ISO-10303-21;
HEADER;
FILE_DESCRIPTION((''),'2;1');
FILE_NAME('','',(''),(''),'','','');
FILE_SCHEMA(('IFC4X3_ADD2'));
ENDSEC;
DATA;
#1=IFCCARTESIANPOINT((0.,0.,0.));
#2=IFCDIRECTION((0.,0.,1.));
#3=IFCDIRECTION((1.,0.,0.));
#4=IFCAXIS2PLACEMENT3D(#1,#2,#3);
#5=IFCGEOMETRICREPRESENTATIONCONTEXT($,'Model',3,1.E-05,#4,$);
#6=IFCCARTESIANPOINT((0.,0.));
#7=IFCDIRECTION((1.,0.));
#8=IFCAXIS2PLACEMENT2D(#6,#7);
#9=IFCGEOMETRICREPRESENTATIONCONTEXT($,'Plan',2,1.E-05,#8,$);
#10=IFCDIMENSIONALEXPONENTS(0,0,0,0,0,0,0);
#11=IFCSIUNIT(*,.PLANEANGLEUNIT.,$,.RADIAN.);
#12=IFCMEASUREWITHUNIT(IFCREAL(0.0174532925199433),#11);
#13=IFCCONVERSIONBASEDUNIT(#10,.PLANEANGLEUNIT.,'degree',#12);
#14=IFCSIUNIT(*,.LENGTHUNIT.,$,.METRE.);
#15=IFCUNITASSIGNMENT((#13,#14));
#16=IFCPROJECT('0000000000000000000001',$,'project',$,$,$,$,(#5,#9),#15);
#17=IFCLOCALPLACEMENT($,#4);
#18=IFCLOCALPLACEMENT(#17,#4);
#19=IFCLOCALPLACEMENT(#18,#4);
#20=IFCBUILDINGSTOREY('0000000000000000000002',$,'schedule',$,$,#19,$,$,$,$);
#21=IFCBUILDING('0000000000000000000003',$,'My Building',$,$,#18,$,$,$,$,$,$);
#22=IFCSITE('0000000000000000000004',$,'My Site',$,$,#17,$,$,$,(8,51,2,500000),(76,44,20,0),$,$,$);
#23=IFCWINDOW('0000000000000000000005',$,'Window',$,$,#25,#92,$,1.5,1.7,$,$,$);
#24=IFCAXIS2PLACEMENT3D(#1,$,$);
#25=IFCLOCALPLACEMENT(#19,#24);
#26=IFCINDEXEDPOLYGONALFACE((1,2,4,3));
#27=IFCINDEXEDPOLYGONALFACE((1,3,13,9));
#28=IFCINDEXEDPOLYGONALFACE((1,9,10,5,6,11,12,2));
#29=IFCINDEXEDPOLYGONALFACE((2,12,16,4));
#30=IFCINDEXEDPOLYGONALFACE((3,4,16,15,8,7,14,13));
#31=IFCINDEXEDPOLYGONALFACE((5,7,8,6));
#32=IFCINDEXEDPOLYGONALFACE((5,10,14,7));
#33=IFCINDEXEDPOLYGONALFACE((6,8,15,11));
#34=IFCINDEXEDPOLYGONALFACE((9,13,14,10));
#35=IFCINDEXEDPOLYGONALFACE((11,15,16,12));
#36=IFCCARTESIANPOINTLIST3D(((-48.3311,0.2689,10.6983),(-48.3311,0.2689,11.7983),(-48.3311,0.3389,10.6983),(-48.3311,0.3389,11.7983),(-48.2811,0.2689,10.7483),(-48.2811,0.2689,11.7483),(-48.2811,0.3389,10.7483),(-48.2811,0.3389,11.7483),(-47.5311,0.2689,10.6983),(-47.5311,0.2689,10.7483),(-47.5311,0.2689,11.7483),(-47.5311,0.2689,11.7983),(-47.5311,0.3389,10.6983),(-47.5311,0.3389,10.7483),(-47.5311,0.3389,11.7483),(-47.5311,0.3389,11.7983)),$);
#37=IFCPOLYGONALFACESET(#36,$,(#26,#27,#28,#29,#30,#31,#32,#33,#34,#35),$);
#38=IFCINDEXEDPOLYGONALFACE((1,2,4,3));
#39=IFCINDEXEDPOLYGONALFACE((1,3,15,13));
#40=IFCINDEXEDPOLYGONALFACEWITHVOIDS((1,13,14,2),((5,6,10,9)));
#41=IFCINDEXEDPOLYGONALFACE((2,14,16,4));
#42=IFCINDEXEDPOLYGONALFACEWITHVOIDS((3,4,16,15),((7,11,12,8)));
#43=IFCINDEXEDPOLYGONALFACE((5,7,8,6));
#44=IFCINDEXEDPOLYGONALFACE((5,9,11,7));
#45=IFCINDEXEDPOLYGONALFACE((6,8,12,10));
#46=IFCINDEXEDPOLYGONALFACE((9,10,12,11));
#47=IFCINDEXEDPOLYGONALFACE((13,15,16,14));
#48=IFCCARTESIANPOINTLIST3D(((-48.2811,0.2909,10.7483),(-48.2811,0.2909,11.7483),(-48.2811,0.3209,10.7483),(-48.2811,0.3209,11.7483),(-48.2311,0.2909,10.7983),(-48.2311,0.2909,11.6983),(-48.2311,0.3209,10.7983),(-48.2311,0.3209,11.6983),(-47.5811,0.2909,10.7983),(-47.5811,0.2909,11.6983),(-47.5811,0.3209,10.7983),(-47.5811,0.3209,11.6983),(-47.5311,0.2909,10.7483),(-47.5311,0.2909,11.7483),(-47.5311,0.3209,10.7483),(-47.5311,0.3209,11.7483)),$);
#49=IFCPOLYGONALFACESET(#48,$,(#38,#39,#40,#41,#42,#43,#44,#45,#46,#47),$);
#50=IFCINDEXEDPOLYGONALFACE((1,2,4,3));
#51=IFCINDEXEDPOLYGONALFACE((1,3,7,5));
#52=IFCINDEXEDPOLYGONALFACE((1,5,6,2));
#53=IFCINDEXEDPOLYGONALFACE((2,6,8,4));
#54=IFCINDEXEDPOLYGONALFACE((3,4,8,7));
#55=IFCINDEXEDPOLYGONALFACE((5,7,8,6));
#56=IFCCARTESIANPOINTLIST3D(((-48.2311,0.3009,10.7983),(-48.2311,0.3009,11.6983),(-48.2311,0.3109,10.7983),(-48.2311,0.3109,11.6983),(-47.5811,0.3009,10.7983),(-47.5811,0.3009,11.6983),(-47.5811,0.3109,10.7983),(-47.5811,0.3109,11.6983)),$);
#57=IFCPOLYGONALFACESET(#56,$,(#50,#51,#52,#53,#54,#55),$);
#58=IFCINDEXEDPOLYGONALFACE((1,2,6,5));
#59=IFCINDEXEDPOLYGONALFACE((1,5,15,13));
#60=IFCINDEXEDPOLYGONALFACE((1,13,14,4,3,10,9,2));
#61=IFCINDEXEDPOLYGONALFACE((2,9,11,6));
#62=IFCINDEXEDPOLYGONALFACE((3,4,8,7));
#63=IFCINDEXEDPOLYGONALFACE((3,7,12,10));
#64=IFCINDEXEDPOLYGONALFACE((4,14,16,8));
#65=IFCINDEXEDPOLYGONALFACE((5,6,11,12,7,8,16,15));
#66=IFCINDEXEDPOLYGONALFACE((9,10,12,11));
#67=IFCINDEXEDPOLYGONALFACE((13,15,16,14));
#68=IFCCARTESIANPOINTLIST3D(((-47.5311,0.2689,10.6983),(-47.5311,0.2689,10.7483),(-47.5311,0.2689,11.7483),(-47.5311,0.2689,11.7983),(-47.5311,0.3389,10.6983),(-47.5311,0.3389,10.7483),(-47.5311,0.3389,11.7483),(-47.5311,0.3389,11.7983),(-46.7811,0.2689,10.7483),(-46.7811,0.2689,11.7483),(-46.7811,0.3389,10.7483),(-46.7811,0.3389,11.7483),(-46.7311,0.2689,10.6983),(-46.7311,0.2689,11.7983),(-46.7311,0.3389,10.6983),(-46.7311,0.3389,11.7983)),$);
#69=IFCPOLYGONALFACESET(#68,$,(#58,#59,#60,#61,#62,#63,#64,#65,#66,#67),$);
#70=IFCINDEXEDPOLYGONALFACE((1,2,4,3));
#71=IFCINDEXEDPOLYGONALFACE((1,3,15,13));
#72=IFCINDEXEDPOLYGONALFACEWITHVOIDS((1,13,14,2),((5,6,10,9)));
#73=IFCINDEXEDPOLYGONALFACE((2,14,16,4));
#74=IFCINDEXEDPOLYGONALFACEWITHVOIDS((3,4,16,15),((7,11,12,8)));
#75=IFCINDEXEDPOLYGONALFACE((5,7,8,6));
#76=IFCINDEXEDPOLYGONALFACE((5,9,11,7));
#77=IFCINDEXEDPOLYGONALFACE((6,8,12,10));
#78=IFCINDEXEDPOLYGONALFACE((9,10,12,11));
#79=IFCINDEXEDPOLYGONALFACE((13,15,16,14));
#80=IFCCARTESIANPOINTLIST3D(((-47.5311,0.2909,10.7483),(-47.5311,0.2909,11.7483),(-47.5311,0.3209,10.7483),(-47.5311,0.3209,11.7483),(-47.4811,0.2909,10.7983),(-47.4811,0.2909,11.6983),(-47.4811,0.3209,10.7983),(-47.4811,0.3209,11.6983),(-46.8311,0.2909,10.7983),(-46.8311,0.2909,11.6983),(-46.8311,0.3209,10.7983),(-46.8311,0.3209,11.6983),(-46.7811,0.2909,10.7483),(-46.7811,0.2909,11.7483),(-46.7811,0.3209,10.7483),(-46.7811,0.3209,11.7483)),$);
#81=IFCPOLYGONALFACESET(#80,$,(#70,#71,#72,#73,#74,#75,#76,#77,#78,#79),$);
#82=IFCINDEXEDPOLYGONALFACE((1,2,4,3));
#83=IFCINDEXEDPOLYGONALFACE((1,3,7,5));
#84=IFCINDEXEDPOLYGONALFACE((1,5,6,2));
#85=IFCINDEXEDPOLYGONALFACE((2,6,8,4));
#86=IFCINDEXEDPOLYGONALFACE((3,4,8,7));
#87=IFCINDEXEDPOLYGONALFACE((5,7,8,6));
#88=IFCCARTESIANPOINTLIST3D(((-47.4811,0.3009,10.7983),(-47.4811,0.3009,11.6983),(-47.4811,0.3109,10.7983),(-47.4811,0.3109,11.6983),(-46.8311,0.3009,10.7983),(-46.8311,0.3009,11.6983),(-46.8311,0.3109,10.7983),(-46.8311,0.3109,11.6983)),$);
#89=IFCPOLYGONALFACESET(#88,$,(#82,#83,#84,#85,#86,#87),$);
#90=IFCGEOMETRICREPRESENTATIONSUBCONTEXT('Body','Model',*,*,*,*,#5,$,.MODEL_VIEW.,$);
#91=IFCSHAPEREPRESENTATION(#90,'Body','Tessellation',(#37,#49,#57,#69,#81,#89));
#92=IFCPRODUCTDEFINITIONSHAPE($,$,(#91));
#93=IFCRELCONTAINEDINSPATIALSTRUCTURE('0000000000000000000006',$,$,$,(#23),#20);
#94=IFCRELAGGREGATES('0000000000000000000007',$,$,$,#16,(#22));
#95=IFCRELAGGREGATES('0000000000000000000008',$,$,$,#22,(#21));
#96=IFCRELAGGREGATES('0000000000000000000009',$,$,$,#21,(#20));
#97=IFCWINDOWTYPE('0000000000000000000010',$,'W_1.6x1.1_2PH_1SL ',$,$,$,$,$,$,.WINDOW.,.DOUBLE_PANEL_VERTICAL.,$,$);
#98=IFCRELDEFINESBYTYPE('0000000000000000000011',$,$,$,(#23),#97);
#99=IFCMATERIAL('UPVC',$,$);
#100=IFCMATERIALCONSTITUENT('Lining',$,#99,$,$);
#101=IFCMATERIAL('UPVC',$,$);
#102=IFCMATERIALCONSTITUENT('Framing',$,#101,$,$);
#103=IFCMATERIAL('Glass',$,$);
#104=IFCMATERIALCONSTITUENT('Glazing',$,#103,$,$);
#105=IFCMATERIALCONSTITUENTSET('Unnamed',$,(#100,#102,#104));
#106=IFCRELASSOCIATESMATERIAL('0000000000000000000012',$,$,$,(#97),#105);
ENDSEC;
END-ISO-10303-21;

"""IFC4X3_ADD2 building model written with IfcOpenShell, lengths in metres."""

from ifc_helpers import new_model, entity, si_unit, converted_unit, frame, origin_with_axes, origin_2d_with_axis, place, context, subcontext, project, spatial, line, indexed_curve, outline, extrude, shape, source, transform, mapped, material, constituent, constituent_set, type_object, type_shapes, element, save


model = new_model("IFC4X3_ADD2")

# Units and contexts
model_context = context("Model", 3, precision=1e-05, world=origin_with_axes())
plan_context = context("Plan", 2, precision=1e-05, world=origin_2d_with_axis())
body_context_1 = subcontext(model_context, "Body", "Model", "MODEL_VIEW")
body_context_2 = subcontext(plan_context, "Body", "Plan", "PLAN_VIEW")
ifc_project = project(units=[converted_unit("PLANEANGLEUNIT", "degree", entity("IfcReal", 0.0174532925199433), si_unit("PLANEANGLEUNIT", "RADIAN"), dimensions=[0, 0, 0, 0, 0, 0, 0]), si_unit("LENGTHUNIT", "METRE")], contexts=[model_context, plan_context])

# Site, building, storey
site_placement = place(None, origin_with_axes())
site = spatial("IfcSite", under=ifc_project, at=site_placement, Name="My Site", RefLatitude=(8, 51, 2, 500000), RefLongitude=(76, 44, 20, 0))
building_placement = place(site_placement, origin_with_axes())
building = spatial("IfcBuilding", under=site, at=building_placement, Name="My Building")
storey_placement = place(building_placement, origin_with_axes())
storey = spatial("IfcBuildingStorey", under=building, at=storey_placement, Name="schedule")

# Window
ifc_material_1 = material(Name="UPVC")
ifc_material_2 = material(Name="UPVC")
ifc_material_3 = material(Name="Glass")
placement_1 = place(storey_placement, frame((-67.8485, 0.2689, 3.1152), z_axis=(0.0, 0.0, 1.0), x_axis=(1.0, 0.0, 0.0)))
ifc_constituent_1 = constituent(ifc_material_1, Name="Lining")
ifc_constituent_2 = constituent(ifc_material_2, Name="Framing")
ifc_constituent_3 = constituent(ifc_material_3, Name="Glazing")
ifc_constituent_set_1 = constituent_set(constituents=[ifc_constituent_1, ifc_constituent_2, ifc_constituent_3], Name="Unnamed")
window_type_1 = type_object("IfcWindowType", Name="W_1.6x1.1_2PH_1SL ", PartitioningType="DOUBLE_PANEL_VERTICAL", PredefinedType="WINDOW", material=ifc_constituent_set_1)
shared_shape_1 = source(origin_with_axes(), body_context_1, "Body", "SweptSolid", [
    extrude(outline(indexed_curve([(0.8, 0.0), (0.0, 0.0), (0.0, 1.1), (0.8, 1.1), (0.8, 1.05), (0.05, 1.05), (0.05, 0.05), (0.8, 0.05)], segments=[line(1, 2, 3, 4, 5, 6, 7, 8, 1)])), frame((0.0, 0.0, 0.0), z_axis=(0.0, -1.0, 0.0), x_axis=(1.0, 0.0, 0.0)), (0.0, 0.0, -1.0), 0.07),
    extrude(outline(indexed_curve([(0.0, 0.0), (0.75, 0.0), (0.75, 1.0), (0.0, 1.0)], segments=[line(1, 2, 3, 4, 1)]), holes=[indexed_curve([(0.05, 0.05), (0.7, 0.05), (0.7, 0.95), (0.05, 0.95)], segments=[line(1, 2, 3, 4, 1)])]), frame((0.05, 0.022, 0.05), z_axis=(0.0, -1.0, 0.0), x_axis=(1.0, 0.0, 0.0)), (0.0, 0.0, -1.0), 0.03),
    extrude(outline(indexed_curve([(0.05, 0.05), (0.7, 0.05), (0.7, 0.95), (0.05, 0.95)], segments=[line(1, 2, 3, 4, 1)])), frame((0.05, 0.032, 0.05), z_axis=(0.0, -1.0, 0.0), x_axis=(1.0, 0.0, 0.0)), (0.0, 0.0, -1.0), 0.01),
    extrude(outline(indexed_curve([(0.0, 1.1), (0.8, 1.1), (0.8, 0.0), (0.0, 0.0), (0.0, 0.05), (0.75, 0.05), (0.75, 1.05), (0.0, 1.05)], segments=[line(1, 2, 3, 4, 5, 6, 7, 8, 1)])), frame((0.8, 0.0, 0.0), z_axis=(0.0, -1.0, 0.0), x_axis=(1.0, 0.0, 0.0)), (0.0, 0.0, -1.0), 0.07),
    extrude(outline(indexed_curve([(0.0, 0.0), (0.75, 0.0), (0.75, 1.0), (0.0, 1.0)], segments=[line(1, 2, 3, 4, 1)]), holes=[indexed_curve([(0.05, 0.05), (0.7, 0.05), (0.7, 0.95), (0.05, 0.95)], segments=[line(1, 2, 3, 4, 1)])]), frame((0.8, 0.022, 0.05), z_axis=(0.0, -1.0, 0.0), x_axis=(1.0, 0.0, 0.0)), (0.0, 0.0, -1.0), 0.03),
    extrude(outline(indexed_curve([(0.05, 0.05), (0.7, 0.05), (0.7, 0.95), (0.05, 0.95)], segments=[line(1, 2, 3, 4, 1)])), frame((0.8, 0.032, 0.05), z_axis=(0.0, -1.0, 0.0), x_axis=(1.0, 0.0, 0.0)), (0.0, 0.0, -1.0), 0.01),
])
shared_shape_2 = source(origin_with_axes(), body_context_2, "Body", "Curve2D", [
    entity("IfcIndexedPolyCurve", entity("IfcCartesianPointList2D", [[0.05, 0.0], [0.8, 0.0]])),
    entity("IfcIndexedPolyCurve", entity("IfcCartesianPointList2D", [[0.0, 0.07], [0.05, 0.07], [0.05, 0.0], [0.0, 0.0]]), [entity("IfcLineIndex", [1, 2, 3, 4, 1])]),
    entity("IfcIndexedPolyCurve", entity("IfcCartesianPointList2D", [[0.8, 0.07], [0.8, 0.07], [0.8, 0.0], [0.8, 0.0]])),
    entity("IfcIndexedPolyCurve", entity("IfcCartesianPointList2D", [[0.05, 0.022], [0.1, 0.022], [0.1, 0.052], [0.05, 0.052]]), [entity("IfcLineIndex", [1, 2, 3, 4, 1])]),
    entity("IfcIndexedPolyCurve", entity("IfcCartesianPointList2D", [[0.8, 0.022], [0.75, 0.022], [0.75, 0.052], [0.8, 0.052]]), [entity("IfcLineIndex", [1, 2, 3, 4, 1])]),
    entity("IfcIndexedPolyCurve", entity("IfcCartesianPointList2D", [[0.1, 0.022], [0.75, 0.022]])),
    entity("IfcIndexedPolyCurve", entity("IfcCartesianPointList2D", [[0.1, 0.052], [0.75, 0.052]])),
    entity("IfcIndexedPolyCurve", entity("IfcCartesianPointList2D", [[0.1, 0.037], [0.75, 0.037]])),
    entity("IfcIndexedPolyCurve", entity("IfcCartesianPointList2D", [[0.8, 0.0], [1.55, 0.0]])),
    entity("IfcIndexedPolyCurve", entity("IfcCartesianPointList2D", [[0.8, 0.07], [0.8, 0.07], [0.8, 0.0], [0.8, 0.0]])),
    entity("IfcIndexedPolyCurve", entity("IfcCartesianPointList2D", [[1.6, 0.07], [1.55, 0.07], [1.55, 0.0], [1.6, 0.0]]), [entity("IfcLineIndex", [1, 2, 3, 4, 1])]),
    entity("IfcIndexedPolyCurve", entity("IfcCartesianPointList2D", [[0.8, 0.022], [0.85, 0.022], [0.85, 0.052], [0.8, 0.052]]), [entity("IfcLineIndex", [1, 2, 3, 4, 1])]),
    entity("IfcIndexedPolyCurve", entity("IfcCartesianPointList2D", [[1.55, 0.022], [1.5, 0.022], [1.5, 0.052], [1.55, 0.052]]), [entity("IfcLineIndex", [1, 2, 3, 4, 1])]),
    entity("IfcIndexedPolyCurve", entity("IfcCartesianPointList2D", [[0.85, 0.022], [1.5, 0.022]])),
    entity("IfcIndexedPolyCurve", entity("IfcCartesianPointList2D", [[0.85, 0.052], [1.5, 0.052]])),
    entity("IfcIndexedPolyCurve", entity("IfcCartesianPointList2D", [[0.85, 0.037], [1.5, 0.037]])),
])
type_shapes(window_type_1, [shared_shape_1, shared_shape_2])
placement_2 = place(placement_1, frame((19.5174, 0.0, 7.5831), z_axis=(0.0, 0.0, 1.0), x_axis=(1.0, 0.0, 0.0)))
window_1_placement = place(placement_2, origin_with_axes())
element("IfcWindow", 1, at=window_1_placement, inside=storey, type_object=window_type_1, Name="Window", OverallHeight=1.5, OverallWidth=1.7, shapes=[
    shape(body_context_1, "Body", "MappedRepresentation", [mapped(shared_shape_1, transform((0.0, 0.0, 0.0), x_axis=(1.0, 0.0, 0.0), y_axis=(0.0, 1.0, 0.0), z_axis=(0.0, 0.0, 1.0), scale=1.0))]),
    shape(body_context_2, "Body", "MappedRepresentation", [mapped(shared_shape_2, transform((0.0, 0.0, 0.0), x_axis=(1.0, 0.0, 0.0), y_axis=(0.0, 1.0, 0.0), z_axis=(0.0, 0.0, 1.0), scale=1.0))]),
])

save(model, "model.ifc")
